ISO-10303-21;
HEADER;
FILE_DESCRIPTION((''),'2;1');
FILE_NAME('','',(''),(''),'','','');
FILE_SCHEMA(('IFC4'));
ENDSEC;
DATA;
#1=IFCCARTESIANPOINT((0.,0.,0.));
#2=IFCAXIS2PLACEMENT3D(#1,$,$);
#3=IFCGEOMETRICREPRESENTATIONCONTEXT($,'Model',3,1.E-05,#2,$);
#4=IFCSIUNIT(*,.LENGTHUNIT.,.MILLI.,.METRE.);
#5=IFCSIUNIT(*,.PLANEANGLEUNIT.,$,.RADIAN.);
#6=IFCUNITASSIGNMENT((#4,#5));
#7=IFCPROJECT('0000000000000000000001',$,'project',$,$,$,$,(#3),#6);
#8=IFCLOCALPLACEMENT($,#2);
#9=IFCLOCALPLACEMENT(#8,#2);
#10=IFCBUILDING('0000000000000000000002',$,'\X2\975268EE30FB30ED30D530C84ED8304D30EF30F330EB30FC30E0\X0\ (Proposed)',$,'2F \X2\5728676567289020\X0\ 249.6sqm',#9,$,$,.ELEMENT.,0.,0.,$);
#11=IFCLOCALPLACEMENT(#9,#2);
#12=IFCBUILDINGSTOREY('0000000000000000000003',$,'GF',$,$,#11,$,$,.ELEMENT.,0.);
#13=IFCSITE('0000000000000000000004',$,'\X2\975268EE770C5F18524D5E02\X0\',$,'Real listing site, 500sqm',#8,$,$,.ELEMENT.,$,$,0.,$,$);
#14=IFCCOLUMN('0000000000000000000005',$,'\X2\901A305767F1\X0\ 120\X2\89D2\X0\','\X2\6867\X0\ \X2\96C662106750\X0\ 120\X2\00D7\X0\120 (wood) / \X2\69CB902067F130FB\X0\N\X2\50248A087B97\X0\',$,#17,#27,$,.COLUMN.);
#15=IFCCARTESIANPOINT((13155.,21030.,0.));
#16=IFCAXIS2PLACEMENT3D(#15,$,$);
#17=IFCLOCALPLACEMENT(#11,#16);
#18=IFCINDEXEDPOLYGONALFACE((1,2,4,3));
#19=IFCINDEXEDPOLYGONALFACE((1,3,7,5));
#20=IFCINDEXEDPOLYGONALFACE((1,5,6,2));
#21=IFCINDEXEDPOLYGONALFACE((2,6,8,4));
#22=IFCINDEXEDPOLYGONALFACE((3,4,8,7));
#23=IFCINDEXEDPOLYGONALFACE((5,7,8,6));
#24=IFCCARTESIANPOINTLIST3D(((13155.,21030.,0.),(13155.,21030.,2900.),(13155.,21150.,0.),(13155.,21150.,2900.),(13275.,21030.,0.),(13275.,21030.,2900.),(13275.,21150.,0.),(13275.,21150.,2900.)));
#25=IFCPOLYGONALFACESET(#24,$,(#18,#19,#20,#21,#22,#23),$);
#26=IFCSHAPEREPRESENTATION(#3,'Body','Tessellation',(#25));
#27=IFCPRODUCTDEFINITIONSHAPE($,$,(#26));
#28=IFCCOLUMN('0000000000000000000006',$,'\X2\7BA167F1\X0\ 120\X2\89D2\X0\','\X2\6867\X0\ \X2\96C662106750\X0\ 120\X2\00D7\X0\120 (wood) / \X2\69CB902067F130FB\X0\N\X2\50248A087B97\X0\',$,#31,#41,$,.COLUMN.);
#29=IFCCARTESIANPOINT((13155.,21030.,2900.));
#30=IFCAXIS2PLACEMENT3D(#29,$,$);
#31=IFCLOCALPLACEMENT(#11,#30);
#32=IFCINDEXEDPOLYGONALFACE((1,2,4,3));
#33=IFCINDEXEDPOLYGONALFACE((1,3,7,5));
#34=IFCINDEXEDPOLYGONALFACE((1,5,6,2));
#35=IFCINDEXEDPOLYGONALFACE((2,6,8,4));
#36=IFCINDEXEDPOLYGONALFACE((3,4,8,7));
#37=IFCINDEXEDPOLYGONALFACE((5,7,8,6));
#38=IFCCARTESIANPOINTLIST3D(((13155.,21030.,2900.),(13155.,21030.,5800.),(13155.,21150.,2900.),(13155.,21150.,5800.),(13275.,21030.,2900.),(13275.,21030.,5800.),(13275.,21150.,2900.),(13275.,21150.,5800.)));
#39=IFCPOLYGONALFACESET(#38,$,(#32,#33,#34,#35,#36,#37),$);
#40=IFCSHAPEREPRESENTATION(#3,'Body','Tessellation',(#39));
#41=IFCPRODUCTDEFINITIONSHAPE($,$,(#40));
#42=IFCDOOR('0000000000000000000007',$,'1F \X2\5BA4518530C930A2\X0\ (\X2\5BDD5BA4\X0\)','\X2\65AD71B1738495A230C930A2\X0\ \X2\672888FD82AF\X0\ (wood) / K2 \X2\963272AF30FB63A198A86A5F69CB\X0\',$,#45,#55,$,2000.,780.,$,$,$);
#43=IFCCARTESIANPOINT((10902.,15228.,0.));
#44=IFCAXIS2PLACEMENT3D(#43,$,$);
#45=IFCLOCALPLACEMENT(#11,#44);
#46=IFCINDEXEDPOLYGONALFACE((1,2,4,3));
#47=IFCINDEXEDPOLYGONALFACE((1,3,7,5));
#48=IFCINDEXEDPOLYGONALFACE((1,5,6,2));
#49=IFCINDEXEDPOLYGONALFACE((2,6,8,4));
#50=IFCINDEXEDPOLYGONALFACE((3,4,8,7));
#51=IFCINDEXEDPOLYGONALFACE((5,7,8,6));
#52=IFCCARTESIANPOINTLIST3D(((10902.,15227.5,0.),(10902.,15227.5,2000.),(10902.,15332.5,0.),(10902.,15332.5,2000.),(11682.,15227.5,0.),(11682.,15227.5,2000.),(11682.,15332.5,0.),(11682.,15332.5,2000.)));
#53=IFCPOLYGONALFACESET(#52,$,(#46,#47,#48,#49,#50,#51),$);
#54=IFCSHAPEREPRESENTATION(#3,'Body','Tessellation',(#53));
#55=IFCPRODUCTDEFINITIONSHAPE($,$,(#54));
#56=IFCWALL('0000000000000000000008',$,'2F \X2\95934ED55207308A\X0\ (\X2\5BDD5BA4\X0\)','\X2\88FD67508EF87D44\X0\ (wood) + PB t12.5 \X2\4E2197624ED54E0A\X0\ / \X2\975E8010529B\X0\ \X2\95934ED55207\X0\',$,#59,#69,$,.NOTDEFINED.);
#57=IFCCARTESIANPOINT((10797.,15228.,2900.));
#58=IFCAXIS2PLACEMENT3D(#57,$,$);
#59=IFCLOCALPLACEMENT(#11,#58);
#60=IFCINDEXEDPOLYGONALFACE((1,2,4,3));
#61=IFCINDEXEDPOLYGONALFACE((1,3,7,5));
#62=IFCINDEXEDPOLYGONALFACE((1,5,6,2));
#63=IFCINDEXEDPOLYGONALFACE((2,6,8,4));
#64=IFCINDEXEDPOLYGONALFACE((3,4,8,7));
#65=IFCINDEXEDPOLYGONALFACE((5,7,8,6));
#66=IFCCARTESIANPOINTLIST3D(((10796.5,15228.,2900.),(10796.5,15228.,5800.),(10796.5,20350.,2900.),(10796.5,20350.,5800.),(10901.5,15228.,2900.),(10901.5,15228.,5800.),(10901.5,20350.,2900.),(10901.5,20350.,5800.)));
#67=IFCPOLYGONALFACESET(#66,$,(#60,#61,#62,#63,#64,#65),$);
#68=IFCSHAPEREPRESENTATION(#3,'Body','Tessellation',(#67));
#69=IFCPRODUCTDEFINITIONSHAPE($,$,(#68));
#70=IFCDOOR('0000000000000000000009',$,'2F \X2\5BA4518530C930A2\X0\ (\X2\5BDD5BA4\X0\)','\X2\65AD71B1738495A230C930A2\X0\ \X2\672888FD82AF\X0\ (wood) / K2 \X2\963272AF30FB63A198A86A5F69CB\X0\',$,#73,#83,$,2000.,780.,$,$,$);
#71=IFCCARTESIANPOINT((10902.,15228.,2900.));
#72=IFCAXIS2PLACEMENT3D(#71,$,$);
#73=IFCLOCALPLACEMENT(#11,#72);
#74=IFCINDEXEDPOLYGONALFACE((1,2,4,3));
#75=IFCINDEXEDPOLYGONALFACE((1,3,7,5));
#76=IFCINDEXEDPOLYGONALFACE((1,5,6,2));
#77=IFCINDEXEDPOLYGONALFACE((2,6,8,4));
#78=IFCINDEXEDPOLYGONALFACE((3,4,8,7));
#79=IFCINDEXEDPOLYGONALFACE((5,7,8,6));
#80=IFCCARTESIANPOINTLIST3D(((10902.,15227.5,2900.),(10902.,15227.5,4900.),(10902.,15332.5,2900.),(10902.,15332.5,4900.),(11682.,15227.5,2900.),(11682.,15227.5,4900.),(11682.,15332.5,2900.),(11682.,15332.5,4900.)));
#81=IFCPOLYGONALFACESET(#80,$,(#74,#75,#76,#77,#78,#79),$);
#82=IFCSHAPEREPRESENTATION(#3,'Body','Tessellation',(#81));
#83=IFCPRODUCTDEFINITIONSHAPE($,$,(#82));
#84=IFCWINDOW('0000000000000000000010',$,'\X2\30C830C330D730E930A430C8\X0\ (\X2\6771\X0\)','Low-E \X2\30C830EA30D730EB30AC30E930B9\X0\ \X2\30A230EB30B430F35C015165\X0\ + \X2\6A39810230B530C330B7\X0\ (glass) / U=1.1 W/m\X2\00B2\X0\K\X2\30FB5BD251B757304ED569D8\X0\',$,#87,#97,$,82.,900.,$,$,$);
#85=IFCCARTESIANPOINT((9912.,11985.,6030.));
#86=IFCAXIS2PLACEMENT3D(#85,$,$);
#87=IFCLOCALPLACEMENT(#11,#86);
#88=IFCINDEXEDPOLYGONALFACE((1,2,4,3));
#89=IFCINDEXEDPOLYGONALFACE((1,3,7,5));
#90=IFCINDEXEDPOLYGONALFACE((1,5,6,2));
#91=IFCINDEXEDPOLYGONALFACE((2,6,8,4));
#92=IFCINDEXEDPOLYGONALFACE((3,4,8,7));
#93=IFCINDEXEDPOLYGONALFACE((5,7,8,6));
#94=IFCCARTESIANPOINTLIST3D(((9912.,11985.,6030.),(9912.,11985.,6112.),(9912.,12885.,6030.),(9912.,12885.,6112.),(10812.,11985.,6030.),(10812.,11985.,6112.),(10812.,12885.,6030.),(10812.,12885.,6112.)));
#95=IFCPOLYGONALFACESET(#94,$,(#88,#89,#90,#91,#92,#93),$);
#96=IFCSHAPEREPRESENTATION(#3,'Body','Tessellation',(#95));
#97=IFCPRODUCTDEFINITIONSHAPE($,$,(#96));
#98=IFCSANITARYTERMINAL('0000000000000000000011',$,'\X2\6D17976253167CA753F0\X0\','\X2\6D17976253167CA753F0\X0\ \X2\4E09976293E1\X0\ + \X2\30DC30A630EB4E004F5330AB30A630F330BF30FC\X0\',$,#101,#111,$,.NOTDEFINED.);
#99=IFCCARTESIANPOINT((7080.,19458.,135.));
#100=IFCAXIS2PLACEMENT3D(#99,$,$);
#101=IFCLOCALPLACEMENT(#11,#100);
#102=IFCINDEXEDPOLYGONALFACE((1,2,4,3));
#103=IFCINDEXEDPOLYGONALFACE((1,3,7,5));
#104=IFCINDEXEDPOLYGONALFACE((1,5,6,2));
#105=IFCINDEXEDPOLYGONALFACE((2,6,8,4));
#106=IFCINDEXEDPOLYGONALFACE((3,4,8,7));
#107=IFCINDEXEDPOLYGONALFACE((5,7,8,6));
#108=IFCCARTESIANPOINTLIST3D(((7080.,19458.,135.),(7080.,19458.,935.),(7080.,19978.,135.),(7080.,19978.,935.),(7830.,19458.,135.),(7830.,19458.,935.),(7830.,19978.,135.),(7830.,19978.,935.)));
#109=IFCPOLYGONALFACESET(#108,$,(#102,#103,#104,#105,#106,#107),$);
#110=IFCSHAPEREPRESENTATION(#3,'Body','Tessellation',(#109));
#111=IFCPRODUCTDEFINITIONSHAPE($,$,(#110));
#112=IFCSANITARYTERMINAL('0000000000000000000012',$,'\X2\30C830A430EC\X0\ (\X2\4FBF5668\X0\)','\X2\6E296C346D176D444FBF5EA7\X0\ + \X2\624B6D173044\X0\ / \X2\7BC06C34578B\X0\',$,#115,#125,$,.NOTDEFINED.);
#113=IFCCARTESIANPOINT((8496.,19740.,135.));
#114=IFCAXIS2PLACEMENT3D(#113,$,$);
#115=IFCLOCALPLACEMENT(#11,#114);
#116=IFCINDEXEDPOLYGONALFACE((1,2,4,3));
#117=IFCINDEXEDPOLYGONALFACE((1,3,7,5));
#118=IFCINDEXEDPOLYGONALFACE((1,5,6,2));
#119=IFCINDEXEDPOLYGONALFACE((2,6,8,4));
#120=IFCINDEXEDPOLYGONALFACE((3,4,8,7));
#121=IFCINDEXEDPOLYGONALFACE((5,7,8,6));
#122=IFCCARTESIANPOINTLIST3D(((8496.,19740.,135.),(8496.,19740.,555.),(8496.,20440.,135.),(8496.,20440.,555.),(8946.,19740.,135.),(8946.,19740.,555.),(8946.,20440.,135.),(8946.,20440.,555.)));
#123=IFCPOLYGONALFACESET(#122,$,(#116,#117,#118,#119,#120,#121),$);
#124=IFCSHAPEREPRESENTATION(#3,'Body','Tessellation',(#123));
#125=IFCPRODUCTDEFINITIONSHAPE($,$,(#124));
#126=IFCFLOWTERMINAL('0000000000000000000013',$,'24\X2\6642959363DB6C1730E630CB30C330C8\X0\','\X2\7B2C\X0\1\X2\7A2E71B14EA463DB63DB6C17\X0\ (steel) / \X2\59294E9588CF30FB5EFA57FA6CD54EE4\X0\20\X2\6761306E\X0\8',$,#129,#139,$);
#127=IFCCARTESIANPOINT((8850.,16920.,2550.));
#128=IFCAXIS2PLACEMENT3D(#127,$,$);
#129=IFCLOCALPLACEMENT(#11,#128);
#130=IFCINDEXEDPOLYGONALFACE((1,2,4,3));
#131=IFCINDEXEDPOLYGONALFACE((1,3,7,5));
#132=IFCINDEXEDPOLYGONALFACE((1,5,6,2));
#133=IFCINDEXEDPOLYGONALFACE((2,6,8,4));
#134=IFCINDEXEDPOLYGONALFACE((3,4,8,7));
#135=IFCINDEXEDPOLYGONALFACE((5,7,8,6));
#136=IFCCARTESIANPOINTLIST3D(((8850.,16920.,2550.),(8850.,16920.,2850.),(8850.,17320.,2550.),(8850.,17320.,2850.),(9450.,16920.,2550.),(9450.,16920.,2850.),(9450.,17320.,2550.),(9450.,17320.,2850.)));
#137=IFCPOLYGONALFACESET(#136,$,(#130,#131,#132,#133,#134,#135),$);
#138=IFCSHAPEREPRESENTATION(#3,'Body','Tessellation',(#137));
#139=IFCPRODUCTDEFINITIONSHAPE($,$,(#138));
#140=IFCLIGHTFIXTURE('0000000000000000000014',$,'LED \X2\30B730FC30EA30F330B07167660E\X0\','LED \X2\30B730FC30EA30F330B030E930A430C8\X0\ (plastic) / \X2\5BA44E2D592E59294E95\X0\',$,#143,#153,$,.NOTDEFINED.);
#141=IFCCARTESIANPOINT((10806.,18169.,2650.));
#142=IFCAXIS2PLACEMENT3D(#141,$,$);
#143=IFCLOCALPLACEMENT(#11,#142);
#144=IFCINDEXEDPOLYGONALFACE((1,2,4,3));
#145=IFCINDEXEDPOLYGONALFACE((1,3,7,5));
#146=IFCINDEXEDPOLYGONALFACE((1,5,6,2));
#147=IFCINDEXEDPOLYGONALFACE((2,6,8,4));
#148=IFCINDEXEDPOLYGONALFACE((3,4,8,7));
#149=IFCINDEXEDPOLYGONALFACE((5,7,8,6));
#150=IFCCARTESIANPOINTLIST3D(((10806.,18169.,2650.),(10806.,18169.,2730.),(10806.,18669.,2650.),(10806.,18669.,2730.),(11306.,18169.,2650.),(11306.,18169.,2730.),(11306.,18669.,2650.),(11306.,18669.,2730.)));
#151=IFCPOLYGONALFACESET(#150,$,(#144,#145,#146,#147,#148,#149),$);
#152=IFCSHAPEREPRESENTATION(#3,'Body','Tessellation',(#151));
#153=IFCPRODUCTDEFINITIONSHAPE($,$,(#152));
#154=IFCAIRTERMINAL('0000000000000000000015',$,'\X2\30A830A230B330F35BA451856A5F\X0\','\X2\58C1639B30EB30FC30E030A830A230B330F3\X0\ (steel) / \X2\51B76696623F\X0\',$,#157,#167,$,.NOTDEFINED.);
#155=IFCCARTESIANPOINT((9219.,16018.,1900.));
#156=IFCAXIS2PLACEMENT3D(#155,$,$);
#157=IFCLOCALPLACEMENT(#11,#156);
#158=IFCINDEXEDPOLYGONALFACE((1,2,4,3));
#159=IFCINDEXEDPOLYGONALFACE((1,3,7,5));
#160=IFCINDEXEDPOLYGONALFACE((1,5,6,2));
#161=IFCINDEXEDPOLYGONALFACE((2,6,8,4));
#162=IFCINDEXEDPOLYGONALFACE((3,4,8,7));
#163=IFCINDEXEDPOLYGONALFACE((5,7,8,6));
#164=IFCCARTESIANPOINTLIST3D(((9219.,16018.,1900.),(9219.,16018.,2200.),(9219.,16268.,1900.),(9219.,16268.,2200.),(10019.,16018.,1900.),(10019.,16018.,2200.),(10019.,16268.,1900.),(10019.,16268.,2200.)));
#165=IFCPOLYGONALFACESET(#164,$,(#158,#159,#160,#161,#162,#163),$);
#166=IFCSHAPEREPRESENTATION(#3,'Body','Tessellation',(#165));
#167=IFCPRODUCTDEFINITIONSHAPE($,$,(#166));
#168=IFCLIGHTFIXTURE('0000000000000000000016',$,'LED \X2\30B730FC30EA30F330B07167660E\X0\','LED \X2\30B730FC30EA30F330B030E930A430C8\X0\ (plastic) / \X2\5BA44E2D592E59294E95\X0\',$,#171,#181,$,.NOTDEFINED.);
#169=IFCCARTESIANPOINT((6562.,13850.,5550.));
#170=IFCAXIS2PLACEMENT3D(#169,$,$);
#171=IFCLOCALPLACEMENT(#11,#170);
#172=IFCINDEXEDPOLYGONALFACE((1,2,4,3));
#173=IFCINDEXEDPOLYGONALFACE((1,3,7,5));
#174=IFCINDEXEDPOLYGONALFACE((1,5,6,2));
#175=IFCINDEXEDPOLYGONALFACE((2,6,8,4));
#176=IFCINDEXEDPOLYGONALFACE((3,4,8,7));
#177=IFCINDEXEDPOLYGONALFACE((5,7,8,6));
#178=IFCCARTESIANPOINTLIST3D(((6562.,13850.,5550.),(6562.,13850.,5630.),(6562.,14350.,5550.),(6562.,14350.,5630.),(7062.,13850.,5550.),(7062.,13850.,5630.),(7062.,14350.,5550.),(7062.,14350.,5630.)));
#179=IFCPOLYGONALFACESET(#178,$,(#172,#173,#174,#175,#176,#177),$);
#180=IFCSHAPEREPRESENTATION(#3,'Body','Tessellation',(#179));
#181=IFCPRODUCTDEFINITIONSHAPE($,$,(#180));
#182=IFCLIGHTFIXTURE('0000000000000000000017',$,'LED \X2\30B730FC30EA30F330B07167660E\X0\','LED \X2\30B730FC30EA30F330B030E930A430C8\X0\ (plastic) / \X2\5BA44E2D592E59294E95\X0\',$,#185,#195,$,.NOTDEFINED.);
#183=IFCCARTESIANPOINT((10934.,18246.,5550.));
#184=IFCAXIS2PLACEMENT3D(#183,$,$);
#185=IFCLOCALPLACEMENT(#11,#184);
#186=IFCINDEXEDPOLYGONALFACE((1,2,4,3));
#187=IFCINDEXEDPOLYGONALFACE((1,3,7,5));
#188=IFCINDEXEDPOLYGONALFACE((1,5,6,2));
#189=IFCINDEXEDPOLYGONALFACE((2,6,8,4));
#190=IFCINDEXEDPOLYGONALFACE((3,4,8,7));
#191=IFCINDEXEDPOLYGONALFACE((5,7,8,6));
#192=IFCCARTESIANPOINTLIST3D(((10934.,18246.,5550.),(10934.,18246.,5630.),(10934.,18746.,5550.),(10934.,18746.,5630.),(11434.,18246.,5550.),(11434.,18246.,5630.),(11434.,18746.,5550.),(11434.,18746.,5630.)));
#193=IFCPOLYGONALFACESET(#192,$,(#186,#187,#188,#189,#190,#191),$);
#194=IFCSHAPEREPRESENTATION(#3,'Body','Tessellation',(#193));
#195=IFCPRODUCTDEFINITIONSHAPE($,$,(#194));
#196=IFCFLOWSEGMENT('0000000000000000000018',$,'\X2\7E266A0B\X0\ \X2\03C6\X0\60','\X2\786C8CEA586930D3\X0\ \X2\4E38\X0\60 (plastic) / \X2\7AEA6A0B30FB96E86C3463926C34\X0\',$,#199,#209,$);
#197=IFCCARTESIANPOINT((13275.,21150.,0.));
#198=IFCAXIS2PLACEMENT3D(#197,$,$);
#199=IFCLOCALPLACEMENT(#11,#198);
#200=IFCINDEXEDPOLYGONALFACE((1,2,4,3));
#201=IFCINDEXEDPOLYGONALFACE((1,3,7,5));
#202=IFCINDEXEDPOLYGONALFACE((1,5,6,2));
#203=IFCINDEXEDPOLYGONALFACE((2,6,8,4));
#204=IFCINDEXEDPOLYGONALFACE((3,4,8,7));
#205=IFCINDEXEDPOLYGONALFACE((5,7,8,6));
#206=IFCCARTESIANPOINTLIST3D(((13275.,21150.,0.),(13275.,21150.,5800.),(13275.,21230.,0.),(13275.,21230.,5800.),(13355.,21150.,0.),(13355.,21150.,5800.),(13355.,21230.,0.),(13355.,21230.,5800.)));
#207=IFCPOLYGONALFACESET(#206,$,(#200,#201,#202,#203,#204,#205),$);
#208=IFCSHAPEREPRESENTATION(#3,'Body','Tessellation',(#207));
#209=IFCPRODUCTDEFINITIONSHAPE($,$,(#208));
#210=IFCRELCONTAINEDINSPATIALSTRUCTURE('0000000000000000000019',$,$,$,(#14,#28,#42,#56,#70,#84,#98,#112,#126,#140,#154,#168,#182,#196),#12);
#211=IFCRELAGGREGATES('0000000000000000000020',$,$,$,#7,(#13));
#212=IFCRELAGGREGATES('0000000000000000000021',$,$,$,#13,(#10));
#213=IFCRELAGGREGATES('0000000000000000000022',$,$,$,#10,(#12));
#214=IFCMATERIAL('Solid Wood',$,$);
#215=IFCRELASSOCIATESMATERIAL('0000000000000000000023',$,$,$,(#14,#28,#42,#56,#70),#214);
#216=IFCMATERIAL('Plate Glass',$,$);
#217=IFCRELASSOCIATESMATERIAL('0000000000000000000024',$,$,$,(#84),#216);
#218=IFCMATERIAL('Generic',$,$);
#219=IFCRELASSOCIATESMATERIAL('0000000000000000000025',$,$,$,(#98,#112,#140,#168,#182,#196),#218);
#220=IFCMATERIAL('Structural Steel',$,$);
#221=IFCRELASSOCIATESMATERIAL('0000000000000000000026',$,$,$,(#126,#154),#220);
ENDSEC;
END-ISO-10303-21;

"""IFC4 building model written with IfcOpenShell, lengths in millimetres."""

from ifc_helpers import new_model, si_unit, frame, frame_2d, origin, place, context, project, spatial, rectangle, extrude, material, element, save


model = new_model("IFC4")

# Units and contexts
model_context = context("Model", 3, precision=1e-05, world=origin())
ifc_project = project(units=[si_unit("LENGTHUNIT", "METRE", prefix="MILLI"), si_unit("PLANEANGLEUNIT", "RADIAN")], contexts=[model_context])

# Site, building, storey
site_placement = place(None, origin())
site = spatial("IfcSite", under=ifc_project, at=site_placement, Name="青森県弘前市", ObjectType="Real listing site, 500sqm", CompositionType="ELEMENT", RefElevation=0.0)
building_placement = place(site_placement, origin())
building = spatial("IfcBuilding", under=site, at=building_placement, Name="青森・ロフト付きワンルーム (Proposed)", ObjectType="2F 在来木造 249.6sqm", CompositionType="ELEMENT", ElevationOfRefHeight=0.0, ElevationOfTerrain=0.0)
storey_placement = place(building_placement, origin())
storey = spatial("IfcBuildingStorey", under=building, at=storey_placement, Name="GF", CompositionType="ELEMENT", Elevation=0.0)

# Columns
ifc_material_1 = material(Name="Solid Wood")
column_1_placement = place(storey_placement, frame((13155.0, 21030.0, 0.0)))
element("IfcColumn", 1, at=column_1_placement, inside=storey, material=ifc_material_1, Name="通し柱 120角", Description="桧 集成材 120×120 (wood) / 構造柱・N値計算", PredefinedType="COLUMN", context=model_context, shape_type="SweptSolid", body=[
    extrude(rectangle(XDim=120.0, YDim=120.0, at=frame_2d((60.0, 60.0))), frame((13155.0, 21030.0, 0.0)), (0.0, 0.0, 1.0), 2900.0),
])
column_2_placement = place(storey_placement, frame((13155.0, 21030.0, 2900.0)))
element("IfcColumn", 2, at=column_2_placement, inside=storey, material=ifc_material_1, Name="管柱 120角", Description="桧 集成材 120×120 (wood) / 構造柱・N値計算", PredefinedType="COLUMN", context=model_context, shape_type="SweptSolid", body=[
    extrude(rectangle(XDim=120.0, YDim=120.0, at=frame_2d((60.0, 60.0))), frame((13155.0, 21030.0, 2900.0)), (0.0, 0.0, 1.0), 2900.0),
])

# Door
door_1_placement = place(storey_placement, frame((10902.0, 15228.0, 0.0)))
element("IfcDoor", 3, at=door_1_placement, inside=storey, material=ifc_material_1, Name="1F 室内ドア (寝室)", Description="断熱玄関ドア 木製芯 (wood) / K2 防犯・採風機構", OverallHeight=2000.0, OverallWidth=780.0, context=model_context, shape_type="SweptSolid", body=[
    extrude(rectangle(XDim=780.0, YDim=105.0, at=frame_2d((390.0, 52.0))), frame((10902.0, 15228.0, 0.0)), (0.0, 0.0, 1.0), 2000.0),
])

# Wall
wall_1_placement = place(storey_placement, frame((10797.0, 15228.0, 2900.0)))
element("IfcWall", 4, at=wall_1_placement, inside=storey, material=ifc_material_1, Name="2F 間仕切り (寝室)", Description="製材軸組 (wood) + PB t12.5 両面仕上 / 非耐力 間仕切", PredefinedType="NOTDEFINED", context=model_context, shape_type="SweptSolid", body=[
    extrude(rectangle(XDim=105.0, YDim=5122.0, at=frame_2d((52.0, 2561.0))), frame((10797.0, 15228.0, 2900.0)), (0.0, 0.0, 1.0), 2900.0),
])

# Door
door_2_placement = place(storey_placement, frame((10902.0, 15228.0, 2900.0)))
element("IfcDoor", 5, at=door_2_placement, inside=storey, material=ifc_material_1, Name="2F 室内ドア (寝室)", Description="断熱玄関ドア 木製芯 (wood) / K2 防犯・採風機構", OverallHeight=2000.0, OverallWidth=780.0, context=model_context, shape_type="SweptSolid", body=[
    extrude(rectangle(XDim=780.0, YDim=105.0, at=frame_2d((390.0, 52.0))), frame((10902.0, 15228.0, 2900.0)), (0.0, 0.0, 1.0), 2000.0),
])

# Window
ifc_material_2 = material(Name="Plate Glass")
window_placement = place(storey_placement, frame((9912.0, 11985.0, 6030.0)))
element("IfcWindow", 6, at=window_placement, inside=storey, material=ifc_material_2, Name="トップライト (東)", Description="Low-E トリプルガラス アルゴン封入 + 樹脂サッシ (glass) / U=1.1 W/m²K・寒冷地仕様", OverallHeight=82.0, OverallWidth=900.0, context=model_context, shape_type="SweptSolid", body=[
    extrude(rectangle(XDim=900.0, YDim=900.0, at=frame_2d((450.0, 450.0))), frame((9912.0, 11985.0, 6030.0)), (0.0, 0.0, 1.0), 82.0),
])

# Sanitary terminals
ifc_material_3 = material(Name="Generic")
sanitary_terminal_1_placement = place(storey_placement, frame((7080.0, 19458.0, 135.0)))
element("IfcSanitaryTerminal", 7, at=sanitary_terminal_1_placement, inside=storey, material=ifc_material_3, Name="洗面化粧台", Description="洗面化粧台 三面鏡 + ボウル一体カウンター", PredefinedType="NOTDEFINED", context=model_context, shape_type="SweptSolid", body=[
    extrude(rectangle(XDim=750.0, YDim=520.0, at=frame_2d((375.0, 260.0))), frame((7080.0, 19458.0, 135.0)), (0.0, 0.0, 1.0), 800.0),
])
sanitary_terminal_2_placement = place(storey_placement, frame((8496.0, 19740.0, 135.0)))
element("IfcSanitaryTerminal", 8, at=sanitary_terminal_2_placement, inside=storey, material=ifc_material_3, Name="トイレ (便器)", Description="温水洗浄便座 + 手洗い / 節水型", PredefinedType="NOTDEFINED", context=model_context, shape_type="SweptSolid", body=[
    extrude(rectangle(XDim=450.0, YDim=700.0, at=frame_2d((225.0, 350.0))), frame((8496.0, 19740.0, 135.0)), (0.0, 0.0, 1.0), 420.0),
])

# Flow terminal
ifc_material_4 = material(Name="Structural Steel")
flow_terminal_placement = place(storey_placement, frame((8850.0, 16920.0, 2550.0)))
element("IfcFlowTerminal", 9, at=flow_terminal_placement, inside=storey, material=ifc_material_4, Name="24時間換気ユニット", Description="第1種熱交換換気 (steel) / 天井裏・建基法令20条の8", context=model_context, shape_type="SweptSolid", body=[
    extrude(rectangle(XDim=600.0, YDim=400.0, at=frame_2d((300.0, 200.0))), frame((8850.0, 16920.0, 2550.0)), (0.0, 0.0, 1.0), 300.0),
])

# Light fixture
light_fixture_1_placement = place(storey_placement, frame((10806.0, 18169.0, 2650.0)))
element("IfcLightFixture", 10, at=light_fixture_1_placement, inside=storey, material=ifc_material_3, Name="LED シーリング照明", Description="LED シーリングライト (plastic) / 室中央天井", PredefinedType="NOTDEFINED", context=model_context, shape_type="SweptSolid", body=[
    extrude(rectangle(XDim=500.0, YDim=500.0, at=frame_2d((250.0, 250.0))), frame((10806.0, 18169.0, 2650.0)), (0.0, 0.0, 1.0), 80.0),
])

# Air terminal
air_terminal_placement = place(storey_placement, frame((9219.0, 16018.0, 1900.0)))
element("IfcAirTerminal", 11, at=air_terminal_placement, inside=storey, material=ifc_material_4, Name="エアコン室内機", Description="壁掛ルームエアコン (steel) / 冷暖房", PredefinedType="NOTDEFINED", context=model_context, shape_type="SweptSolid", body=[
    extrude(rectangle(XDim=800.0, YDim=250.0, at=frame_2d((400.0, 125.0))), frame((9219.0, 16018.0, 1900.0)), (0.0, 0.0, 1.0), 300.0),
])

# Light fixtures
light_fixture_2_placement = place(storey_placement, frame((6562.0, 13850.0, 5550.0)))
element("IfcLightFixture", 12, at=light_fixture_2_placement, inside=storey, material=ifc_material_3, Name="LED シーリング照明", Description="LED シーリングライト (plastic) / 室中央天井", PredefinedType="NOTDEFINED", context=model_context, shape_type="SweptSolid", body=[
    extrude(rectangle(XDim=500.0, YDim=500.0, at=frame_2d((250.0, 250.0))), frame((6562.0, 13850.0, 5550.0)), (0.0, 0.0, 1.0), 80.0),
])
light_fixture_3_placement = place(storey_placement, frame((10934.0, 18246.0, 5550.0)))
element("IfcLightFixture", 13, at=light_fixture_3_placement, inside=storey, material=ifc_material_3, Name="LED シーリング照明", Description="LED シーリングライト (plastic) / 室中央天井", PredefinedType="NOTDEFINED", context=model_context, shape_type="SweptSolid", body=[
    extrude(rectangle(XDim=500.0, YDim=500.0, at=frame_2d((250.0, 250.0))), frame((10934.0, 18246.0, 5550.0)), (0.0, 0.0, 1.0), 80.0),
])

# Flow segment
flow_segment_placement = place(storey_placement, frame((13275.0, 21150.0, 0.0)))
element("IfcFlowSegment", 14, at=flow_segment_placement, inside=storey, material=ifc_material_3, Name="縦樋 φ60", Description="硬質塩ビ 丸60 (plastic) / 竪樋・雨水排水", context=model_context, shape_type="SweptSolid", body=[
    extrude(rectangle(XDim=80.0, YDim=80.0, at=frame_2d((40.0, 40.0))), frame((13275.0, 21150.0, 0.0)), (0.0, 0.0, 1.0), 5800.0),
])

save(model, "model.ifc")
